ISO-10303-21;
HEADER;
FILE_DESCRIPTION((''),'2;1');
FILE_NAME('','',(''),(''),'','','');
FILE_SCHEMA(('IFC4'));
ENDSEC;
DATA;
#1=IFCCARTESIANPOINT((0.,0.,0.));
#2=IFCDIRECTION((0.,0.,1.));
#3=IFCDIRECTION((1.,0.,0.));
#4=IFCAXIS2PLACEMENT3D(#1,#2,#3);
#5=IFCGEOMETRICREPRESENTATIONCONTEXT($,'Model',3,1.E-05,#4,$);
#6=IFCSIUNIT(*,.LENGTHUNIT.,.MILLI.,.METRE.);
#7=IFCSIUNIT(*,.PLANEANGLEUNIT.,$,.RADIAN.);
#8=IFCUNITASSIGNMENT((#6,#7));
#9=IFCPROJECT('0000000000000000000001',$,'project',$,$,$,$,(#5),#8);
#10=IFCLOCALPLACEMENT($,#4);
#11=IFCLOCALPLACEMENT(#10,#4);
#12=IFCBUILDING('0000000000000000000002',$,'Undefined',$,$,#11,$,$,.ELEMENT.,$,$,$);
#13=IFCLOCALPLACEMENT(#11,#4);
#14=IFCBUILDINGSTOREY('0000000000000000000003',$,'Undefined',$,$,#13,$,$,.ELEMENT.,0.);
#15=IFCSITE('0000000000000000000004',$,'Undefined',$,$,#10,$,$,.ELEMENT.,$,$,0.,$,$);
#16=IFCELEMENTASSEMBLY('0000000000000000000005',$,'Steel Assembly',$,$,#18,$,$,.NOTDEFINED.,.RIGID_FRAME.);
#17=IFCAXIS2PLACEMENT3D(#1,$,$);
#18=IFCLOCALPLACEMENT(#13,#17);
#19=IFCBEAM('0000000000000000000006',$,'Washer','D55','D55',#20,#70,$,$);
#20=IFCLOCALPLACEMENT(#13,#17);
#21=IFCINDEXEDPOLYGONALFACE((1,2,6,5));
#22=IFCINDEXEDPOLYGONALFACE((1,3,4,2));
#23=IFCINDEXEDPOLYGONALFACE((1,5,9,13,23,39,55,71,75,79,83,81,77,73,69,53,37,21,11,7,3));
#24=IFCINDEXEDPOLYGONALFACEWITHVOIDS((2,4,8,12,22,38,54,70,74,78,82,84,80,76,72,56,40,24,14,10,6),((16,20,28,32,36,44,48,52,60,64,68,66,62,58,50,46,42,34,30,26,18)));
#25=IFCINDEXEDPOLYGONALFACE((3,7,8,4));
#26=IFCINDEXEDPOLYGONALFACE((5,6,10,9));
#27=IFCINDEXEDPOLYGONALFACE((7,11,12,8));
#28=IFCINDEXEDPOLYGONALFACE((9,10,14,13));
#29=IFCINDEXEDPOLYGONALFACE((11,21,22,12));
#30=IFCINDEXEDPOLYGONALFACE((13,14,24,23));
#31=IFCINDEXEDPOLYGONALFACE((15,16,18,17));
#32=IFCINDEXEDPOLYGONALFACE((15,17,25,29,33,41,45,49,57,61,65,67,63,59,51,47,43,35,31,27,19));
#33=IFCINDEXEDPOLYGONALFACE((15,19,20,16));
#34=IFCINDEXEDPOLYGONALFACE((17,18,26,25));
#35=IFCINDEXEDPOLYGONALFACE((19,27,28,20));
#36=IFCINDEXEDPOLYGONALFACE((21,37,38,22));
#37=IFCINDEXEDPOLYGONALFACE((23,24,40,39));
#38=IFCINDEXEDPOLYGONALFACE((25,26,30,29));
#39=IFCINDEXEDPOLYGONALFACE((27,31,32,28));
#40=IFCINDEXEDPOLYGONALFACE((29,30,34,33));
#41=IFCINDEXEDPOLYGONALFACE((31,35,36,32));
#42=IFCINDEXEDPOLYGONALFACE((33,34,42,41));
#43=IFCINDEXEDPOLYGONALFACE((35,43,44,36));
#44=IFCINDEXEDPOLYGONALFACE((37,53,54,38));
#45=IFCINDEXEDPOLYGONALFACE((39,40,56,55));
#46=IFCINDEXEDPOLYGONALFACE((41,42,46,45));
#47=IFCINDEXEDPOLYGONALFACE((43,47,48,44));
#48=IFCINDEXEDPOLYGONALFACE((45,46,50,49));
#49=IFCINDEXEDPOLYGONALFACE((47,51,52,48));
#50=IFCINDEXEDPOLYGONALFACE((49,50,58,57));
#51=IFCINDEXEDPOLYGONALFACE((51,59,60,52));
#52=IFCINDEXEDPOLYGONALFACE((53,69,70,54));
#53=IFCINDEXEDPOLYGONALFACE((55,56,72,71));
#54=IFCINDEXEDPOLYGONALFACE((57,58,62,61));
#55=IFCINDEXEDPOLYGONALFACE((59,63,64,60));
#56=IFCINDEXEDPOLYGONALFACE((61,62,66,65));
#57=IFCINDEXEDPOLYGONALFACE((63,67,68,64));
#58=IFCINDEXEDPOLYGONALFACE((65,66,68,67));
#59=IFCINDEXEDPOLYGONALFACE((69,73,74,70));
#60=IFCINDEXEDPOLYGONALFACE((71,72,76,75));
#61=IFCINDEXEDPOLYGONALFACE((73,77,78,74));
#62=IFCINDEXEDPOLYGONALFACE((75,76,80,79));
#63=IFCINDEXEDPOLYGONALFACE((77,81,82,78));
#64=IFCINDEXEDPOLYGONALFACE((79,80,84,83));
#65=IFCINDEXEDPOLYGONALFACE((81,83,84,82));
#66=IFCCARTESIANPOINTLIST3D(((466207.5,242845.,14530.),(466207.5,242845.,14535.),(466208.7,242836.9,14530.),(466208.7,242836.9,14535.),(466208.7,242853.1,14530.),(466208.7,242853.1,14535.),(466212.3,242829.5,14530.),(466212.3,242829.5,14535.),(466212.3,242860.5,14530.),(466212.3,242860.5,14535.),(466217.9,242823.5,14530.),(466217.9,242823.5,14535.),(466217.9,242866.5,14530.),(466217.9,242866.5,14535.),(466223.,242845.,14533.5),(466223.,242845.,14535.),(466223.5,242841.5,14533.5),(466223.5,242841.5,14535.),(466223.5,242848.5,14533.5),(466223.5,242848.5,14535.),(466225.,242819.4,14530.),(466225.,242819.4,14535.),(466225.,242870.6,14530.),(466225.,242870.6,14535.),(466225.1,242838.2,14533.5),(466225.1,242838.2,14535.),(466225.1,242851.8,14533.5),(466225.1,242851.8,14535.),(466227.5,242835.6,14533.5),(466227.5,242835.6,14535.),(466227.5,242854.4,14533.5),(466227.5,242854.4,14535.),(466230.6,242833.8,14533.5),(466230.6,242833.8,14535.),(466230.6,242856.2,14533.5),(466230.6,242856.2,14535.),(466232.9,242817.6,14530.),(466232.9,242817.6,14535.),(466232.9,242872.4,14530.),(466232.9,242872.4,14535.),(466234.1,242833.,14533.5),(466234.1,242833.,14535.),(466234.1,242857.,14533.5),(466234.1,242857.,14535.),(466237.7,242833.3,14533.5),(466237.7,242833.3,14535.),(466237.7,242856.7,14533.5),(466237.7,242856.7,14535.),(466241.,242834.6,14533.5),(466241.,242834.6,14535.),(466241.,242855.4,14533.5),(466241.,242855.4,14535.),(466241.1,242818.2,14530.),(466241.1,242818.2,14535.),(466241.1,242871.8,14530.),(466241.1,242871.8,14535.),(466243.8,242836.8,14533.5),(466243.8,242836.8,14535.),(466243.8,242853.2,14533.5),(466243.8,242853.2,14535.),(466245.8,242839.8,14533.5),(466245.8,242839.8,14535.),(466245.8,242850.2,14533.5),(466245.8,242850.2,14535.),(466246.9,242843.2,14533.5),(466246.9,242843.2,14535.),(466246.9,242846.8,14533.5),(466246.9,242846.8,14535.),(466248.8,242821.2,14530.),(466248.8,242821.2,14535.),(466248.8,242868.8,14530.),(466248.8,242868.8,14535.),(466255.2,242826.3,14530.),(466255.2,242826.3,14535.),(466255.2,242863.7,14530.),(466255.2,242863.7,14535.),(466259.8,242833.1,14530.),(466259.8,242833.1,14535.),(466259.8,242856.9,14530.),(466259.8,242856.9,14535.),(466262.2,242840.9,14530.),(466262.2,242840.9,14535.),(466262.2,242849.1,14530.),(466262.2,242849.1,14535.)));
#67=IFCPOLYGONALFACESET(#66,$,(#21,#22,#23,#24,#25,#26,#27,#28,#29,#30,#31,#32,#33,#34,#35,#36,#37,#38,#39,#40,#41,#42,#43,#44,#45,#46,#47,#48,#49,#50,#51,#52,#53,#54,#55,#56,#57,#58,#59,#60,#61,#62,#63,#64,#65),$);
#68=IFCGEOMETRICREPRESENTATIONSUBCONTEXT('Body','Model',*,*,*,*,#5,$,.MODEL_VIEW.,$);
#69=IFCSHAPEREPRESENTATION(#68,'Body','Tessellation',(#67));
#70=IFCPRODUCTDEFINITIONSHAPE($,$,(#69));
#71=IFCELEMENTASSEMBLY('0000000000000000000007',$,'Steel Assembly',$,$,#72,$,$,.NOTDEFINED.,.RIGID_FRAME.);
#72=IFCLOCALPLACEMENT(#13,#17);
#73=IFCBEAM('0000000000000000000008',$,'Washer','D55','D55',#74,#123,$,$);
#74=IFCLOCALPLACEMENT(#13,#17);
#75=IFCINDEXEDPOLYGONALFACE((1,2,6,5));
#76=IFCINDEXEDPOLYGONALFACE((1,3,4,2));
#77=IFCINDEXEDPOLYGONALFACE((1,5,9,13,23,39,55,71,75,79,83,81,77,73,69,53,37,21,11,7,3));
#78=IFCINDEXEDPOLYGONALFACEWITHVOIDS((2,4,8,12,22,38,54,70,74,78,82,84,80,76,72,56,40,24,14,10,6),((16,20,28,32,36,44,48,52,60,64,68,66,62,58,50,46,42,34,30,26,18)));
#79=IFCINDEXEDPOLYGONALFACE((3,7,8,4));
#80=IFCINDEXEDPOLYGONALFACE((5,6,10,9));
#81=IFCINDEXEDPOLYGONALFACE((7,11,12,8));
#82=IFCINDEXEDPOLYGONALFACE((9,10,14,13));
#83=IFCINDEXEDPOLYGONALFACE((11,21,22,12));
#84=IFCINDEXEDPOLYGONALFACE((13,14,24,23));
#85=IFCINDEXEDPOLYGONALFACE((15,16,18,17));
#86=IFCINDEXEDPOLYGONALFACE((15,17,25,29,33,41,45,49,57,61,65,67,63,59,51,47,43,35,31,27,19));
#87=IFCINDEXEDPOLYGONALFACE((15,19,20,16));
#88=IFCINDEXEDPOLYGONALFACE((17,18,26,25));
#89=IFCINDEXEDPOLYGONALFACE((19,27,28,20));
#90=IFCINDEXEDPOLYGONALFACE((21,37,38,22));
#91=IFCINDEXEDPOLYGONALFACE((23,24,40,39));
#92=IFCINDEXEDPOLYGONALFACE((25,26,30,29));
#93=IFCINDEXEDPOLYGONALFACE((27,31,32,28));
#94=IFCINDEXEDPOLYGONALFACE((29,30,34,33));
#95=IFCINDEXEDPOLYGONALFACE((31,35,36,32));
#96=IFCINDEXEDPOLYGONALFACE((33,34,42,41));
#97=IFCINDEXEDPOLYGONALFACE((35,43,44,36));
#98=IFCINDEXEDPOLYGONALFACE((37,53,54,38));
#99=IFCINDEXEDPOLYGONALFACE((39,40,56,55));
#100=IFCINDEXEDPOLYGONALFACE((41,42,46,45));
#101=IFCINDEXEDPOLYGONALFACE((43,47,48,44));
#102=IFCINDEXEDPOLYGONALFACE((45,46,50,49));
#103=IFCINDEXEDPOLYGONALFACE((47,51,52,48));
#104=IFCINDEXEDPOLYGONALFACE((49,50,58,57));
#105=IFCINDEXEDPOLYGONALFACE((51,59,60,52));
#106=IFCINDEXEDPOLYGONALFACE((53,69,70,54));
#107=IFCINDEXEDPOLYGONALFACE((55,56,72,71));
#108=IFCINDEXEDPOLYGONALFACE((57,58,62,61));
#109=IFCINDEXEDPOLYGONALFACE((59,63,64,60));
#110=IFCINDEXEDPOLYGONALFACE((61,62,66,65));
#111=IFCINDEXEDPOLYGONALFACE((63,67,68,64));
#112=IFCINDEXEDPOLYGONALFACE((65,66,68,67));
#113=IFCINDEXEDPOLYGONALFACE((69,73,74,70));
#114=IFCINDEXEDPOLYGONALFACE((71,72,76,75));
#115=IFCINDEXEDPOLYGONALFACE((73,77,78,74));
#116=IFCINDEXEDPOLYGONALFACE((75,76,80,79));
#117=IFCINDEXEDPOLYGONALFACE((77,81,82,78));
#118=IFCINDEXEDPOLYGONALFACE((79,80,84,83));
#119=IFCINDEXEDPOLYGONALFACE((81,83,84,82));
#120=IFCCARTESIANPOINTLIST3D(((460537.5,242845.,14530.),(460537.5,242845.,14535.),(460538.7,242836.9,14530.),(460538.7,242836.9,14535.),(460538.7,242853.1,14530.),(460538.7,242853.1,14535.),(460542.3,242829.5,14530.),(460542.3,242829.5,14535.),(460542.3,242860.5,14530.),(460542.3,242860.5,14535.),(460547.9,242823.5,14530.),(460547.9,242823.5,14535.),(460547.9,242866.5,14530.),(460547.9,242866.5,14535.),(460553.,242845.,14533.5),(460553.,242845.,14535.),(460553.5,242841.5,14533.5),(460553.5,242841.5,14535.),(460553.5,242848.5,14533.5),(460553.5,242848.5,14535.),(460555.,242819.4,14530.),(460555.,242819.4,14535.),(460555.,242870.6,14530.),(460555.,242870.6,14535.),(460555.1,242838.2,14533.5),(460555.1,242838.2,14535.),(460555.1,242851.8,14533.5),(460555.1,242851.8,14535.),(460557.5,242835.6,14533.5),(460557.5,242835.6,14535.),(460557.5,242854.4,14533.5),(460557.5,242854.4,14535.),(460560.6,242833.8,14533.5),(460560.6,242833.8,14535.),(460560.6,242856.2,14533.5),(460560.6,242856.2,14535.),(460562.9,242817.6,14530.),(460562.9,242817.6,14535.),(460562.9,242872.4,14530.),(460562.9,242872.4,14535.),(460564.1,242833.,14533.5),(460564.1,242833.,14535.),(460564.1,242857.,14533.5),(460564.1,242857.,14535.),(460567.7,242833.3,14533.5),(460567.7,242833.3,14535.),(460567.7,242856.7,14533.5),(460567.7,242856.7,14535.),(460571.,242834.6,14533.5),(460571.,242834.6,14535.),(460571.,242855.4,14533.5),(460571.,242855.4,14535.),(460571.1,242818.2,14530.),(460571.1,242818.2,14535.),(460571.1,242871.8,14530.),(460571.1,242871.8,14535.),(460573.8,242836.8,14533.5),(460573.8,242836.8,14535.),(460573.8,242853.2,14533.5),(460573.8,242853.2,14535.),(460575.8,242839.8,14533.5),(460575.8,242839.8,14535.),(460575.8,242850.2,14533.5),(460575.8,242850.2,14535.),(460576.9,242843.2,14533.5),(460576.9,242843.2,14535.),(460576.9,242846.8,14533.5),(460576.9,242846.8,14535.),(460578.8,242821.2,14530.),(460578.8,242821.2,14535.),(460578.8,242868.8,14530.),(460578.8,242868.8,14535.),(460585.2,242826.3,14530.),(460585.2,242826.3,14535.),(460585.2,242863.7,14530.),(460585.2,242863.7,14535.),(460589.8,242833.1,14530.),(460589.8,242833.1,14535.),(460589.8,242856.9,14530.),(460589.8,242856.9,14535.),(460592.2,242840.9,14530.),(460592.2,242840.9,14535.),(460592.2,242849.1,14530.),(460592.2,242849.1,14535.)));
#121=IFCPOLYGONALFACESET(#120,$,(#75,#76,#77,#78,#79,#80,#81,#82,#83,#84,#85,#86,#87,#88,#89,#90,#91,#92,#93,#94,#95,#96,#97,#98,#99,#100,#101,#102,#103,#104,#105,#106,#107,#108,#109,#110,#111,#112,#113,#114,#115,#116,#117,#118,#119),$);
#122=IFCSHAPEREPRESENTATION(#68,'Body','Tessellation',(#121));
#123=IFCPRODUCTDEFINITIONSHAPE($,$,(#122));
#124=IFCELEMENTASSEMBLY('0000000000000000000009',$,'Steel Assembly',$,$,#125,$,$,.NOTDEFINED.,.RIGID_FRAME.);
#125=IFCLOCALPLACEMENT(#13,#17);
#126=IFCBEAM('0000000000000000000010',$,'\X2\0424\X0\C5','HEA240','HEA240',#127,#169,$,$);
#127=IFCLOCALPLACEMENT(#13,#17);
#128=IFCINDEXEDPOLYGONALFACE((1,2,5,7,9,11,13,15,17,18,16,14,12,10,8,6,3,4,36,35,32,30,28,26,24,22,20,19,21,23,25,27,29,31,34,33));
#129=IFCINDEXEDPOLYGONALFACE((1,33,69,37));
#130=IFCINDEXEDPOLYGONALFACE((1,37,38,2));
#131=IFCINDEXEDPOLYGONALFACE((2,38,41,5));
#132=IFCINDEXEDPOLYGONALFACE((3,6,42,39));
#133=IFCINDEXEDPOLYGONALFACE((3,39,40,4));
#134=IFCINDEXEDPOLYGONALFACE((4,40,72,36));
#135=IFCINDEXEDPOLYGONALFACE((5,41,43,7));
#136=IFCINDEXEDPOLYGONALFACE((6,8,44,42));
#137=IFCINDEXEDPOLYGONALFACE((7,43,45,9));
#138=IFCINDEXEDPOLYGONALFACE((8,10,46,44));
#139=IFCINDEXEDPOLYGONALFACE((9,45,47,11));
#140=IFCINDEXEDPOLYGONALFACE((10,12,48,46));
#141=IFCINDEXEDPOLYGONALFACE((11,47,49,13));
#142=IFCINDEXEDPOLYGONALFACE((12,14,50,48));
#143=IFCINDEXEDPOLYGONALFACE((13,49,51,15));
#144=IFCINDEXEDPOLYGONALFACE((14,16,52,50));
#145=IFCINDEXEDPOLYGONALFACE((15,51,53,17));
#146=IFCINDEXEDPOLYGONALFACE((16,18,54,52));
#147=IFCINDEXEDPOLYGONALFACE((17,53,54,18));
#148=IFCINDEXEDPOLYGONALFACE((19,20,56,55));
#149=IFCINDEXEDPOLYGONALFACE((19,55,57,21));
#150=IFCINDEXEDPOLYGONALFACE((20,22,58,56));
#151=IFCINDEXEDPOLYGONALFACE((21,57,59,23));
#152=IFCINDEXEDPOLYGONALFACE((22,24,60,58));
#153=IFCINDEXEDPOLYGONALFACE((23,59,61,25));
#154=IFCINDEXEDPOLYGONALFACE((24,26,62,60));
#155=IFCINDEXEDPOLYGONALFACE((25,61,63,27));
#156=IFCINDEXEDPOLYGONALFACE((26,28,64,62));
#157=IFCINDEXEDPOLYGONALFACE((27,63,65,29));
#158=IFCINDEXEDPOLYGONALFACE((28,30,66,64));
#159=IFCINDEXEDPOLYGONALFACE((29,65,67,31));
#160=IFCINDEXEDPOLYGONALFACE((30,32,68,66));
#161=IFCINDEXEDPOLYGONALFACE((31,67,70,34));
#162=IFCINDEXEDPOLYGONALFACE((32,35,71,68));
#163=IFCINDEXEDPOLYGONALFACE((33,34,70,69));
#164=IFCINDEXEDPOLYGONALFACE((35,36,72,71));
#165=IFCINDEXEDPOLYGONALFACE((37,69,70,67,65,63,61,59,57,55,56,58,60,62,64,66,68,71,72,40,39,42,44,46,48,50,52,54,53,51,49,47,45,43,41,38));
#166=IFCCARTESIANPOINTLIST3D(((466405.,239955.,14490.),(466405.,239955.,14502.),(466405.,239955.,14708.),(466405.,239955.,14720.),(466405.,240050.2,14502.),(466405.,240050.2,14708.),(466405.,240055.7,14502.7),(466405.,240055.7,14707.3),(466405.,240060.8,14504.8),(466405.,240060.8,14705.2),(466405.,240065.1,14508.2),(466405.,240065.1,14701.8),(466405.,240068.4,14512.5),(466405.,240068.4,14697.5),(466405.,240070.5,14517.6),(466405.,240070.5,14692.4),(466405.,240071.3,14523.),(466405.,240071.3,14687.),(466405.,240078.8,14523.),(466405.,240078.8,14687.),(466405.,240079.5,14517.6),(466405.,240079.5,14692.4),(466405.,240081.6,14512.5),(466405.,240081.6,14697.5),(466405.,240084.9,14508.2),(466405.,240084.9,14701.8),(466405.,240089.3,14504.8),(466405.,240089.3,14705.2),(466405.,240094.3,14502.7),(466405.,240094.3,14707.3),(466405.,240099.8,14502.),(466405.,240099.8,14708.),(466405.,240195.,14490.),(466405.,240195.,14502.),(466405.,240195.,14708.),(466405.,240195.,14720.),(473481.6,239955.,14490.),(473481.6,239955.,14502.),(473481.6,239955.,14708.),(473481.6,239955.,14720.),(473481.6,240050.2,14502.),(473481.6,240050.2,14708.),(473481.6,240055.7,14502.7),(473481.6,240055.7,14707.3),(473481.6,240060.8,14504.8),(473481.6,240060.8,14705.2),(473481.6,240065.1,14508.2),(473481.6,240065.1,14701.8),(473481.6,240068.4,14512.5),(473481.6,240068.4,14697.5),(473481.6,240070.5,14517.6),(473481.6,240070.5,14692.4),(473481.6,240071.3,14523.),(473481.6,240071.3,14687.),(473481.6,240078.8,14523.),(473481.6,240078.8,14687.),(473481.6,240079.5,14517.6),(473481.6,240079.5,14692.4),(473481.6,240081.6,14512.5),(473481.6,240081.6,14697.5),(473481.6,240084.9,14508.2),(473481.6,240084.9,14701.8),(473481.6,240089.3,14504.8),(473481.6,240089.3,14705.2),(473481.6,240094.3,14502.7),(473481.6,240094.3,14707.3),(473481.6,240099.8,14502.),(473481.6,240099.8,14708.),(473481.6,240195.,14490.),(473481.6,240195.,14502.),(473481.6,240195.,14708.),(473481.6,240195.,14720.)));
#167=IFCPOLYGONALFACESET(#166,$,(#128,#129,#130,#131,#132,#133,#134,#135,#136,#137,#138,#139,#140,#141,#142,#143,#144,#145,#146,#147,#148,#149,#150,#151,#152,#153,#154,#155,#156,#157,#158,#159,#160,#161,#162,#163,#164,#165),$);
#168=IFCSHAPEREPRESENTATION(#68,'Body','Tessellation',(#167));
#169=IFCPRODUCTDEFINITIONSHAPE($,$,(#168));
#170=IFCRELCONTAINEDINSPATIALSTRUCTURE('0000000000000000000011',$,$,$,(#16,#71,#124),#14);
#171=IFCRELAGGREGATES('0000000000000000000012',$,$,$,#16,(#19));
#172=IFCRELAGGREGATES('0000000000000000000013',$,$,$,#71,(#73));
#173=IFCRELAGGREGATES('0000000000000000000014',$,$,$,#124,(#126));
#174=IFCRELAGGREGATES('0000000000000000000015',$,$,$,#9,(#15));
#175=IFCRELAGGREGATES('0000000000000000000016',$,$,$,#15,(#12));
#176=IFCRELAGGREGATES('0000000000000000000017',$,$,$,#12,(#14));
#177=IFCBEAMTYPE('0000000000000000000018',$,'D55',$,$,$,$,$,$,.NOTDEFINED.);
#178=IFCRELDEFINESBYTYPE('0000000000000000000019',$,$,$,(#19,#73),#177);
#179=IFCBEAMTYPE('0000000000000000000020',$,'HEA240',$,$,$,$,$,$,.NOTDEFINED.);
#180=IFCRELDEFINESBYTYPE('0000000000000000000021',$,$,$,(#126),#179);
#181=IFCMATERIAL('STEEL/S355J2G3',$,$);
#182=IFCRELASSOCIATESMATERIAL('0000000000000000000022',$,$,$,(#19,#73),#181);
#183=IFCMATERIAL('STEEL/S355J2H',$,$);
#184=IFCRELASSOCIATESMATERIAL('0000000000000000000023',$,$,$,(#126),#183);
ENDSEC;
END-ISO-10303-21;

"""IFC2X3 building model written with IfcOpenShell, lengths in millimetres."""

from ifc_helpers import new_model, si_unit, frame, origin_with_axes, origin_2d_with_axis, place, context, subcontext, project, spatial, circle, i_section, extrude, boolean, material, type_object, element, aggregate, save


model = new_model("IFC2X3")

# Units and contexts
model_context = context("Model", 3, precision=1e-05, world=origin_with_axes())
body_context = subcontext(model_context, "Body", "Model", "MODEL_VIEW")
ifc_project = project(units=[si_unit("LENGTHUNIT", "METRE", prefix="MILLI"), si_unit("PLANEANGLEUNIT", "RADIAN")], contexts=[model_context])

# Site, building, storey
site_placement = place(None, origin_with_axes())
site = spatial("IfcSite", under=ifc_project, at=site_placement, Name="Undefined", CompositionType="ELEMENT", RefElevation=0.0)
building_placement = place(site_placement, origin_with_axes())
building = spatial("IfcBuilding", under=site, at=building_placement, Name="Undefined", CompositionType="ELEMENT")
storey_placement = place(building_placement, origin_with_axes())
storey = spatial("IfcBuildingStorey", under=building, at=storey_placement, Name="Undefined", CompositionType="ELEMENT", Elevation=0.0)

# Element assemblies, beams
ifc_material_1 = material(Name="STEEL/S355J2G3")
assembly_1_placement = place(storey_placement, origin_with_axes())
assembly_1 = element("IfcElementAssembly", 1, at=assembly_1_placement, inside=storey, Name="Steel Assembly", AssemblyPlace="NOTDEFINED", PredefinedType="RIGID_FRAME")
beam_type_1 = type_object("IfcBeamType", Name="D55", PredefinedType="NOTDEFINED")
beam_1_placement = place(assembly_1_placement, frame((466235.0, 242845.0, 14535.0), z_axis=(0.0, -1.0, 0.0), x_axis=(0.0, 0.0, -1.0)))
beam_1 = element("IfcBeam", 2, at=beam_1_placement, type_object=beam_type_1, material=ifc_material_1, Name="Washer", Description="D55", ObjectType="D55", context=body_context, shape_type="CSG", body=[
    boolean("DIFFERENCE", extrude(circle(Radius=27.5, at=origin_2d_with_axis()), frame((5.0, 0.0, 0.0), z_axis=(-1.0, 0.0, 0.0), x_axis=(0.0, -1.0, 0.0)), (0.0, 0.0, 1.0), 5.0), extrude(circle(Radius=12.0, at=origin_2d_with_axis()), frame((1.5, 0.0, 0.0), z_axis=(-1.0, 0.0, 0.0), x_axis=(0.0, -1.0, 0.0)), (0.0, 0.0, 1.0), 10.0)),
])
aggregate(assembly_1, [beam_1])
assembly_2_placement = place(storey_placement, origin_with_axes())
assembly_2 = element("IfcElementAssembly", 3, at=assembly_2_placement, inside=storey, Name="Steel Assembly", AssemblyPlace="NOTDEFINED", PredefinedType="RIGID_FRAME")
beam_2_placement = place(assembly_2_placement, frame((460565.0, 242845.0, 14535.0), z_axis=(0.0, -1.0, 0.0), x_axis=(0.0, 0.0, -1.0)))
beam_2 = element("IfcBeam", 4, at=beam_2_placement, type_object=beam_type_1, material=ifc_material_1, Name="Washer", Description="D55", ObjectType="D55", context=body_context, shape_type="CSG", body=[
    boolean("DIFFERENCE", extrude(circle(Radius=27.5, at=origin_2d_with_axis()), frame((5.0, 0.0, 0.0), z_axis=(-1.0, 0.0, 0.0), x_axis=(0.0, -1.0, 0.0)), (0.0, 0.0, 1.0), 5.0), extrude(circle(Radius=12.0, at=origin_2d_with_axis()), frame((1.5, 0.0, 0.0), z_axis=(-1.0, 0.0, 0.0), x_axis=(0.0, -1.0, 0.0)), (0.0, 0.0, 1.0), 10.0)),
])
aggregate(assembly_2, [beam_2])
assembly_3_placement = place(storey_placement, origin_with_axes())
assembly_3 = element("IfcElementAssembly", 5, at=assembly_3_placement, inside=storey, Name="Steel Assembly", AssemblyPlace="NOTDEFINED", PredefinedType="RIGID_FRAME")
ifc_material_2 = material(Name="STEEL/S355J2H")
beam_type_2 = type_object("IfcBeamType", Name="HEA240", PredefinedType="NOTDEFINED")
beam_3_placement = place(assembly_3_placement, frame((466405.0, 240075.0, 14605.0), z_axis=(0.0, 0.0, 1.0), x_axis=(1.0, 0.0, 0.0)))
beam_3 = element("IfcBeam", 6, at=beam_3_placement, type_object=beam_type_2, material=ifc_material_2, Name="ФC5", Description="HEA240", ObjectType="HEA240", context=body_context, shape_type="SweptSolid", body=[
    extrude(i_section(OverallWidth=240.0, OverallDepth=230.0, WebThickness=7.5, FlangeThickness=12.0, FilletRadius=21.0, at=origin_2d_with_axis()), frame((7076.6, 0.0, 0.0), z_axis=(-1.0, 0.0, 0.0), x_axis=(0.0, -1.0, 0.0)), (0.0, 0.0, 1.0), 7076.6),
])
aggregate(assembly_3, [beam_3])

save(model, "model.ifc")
